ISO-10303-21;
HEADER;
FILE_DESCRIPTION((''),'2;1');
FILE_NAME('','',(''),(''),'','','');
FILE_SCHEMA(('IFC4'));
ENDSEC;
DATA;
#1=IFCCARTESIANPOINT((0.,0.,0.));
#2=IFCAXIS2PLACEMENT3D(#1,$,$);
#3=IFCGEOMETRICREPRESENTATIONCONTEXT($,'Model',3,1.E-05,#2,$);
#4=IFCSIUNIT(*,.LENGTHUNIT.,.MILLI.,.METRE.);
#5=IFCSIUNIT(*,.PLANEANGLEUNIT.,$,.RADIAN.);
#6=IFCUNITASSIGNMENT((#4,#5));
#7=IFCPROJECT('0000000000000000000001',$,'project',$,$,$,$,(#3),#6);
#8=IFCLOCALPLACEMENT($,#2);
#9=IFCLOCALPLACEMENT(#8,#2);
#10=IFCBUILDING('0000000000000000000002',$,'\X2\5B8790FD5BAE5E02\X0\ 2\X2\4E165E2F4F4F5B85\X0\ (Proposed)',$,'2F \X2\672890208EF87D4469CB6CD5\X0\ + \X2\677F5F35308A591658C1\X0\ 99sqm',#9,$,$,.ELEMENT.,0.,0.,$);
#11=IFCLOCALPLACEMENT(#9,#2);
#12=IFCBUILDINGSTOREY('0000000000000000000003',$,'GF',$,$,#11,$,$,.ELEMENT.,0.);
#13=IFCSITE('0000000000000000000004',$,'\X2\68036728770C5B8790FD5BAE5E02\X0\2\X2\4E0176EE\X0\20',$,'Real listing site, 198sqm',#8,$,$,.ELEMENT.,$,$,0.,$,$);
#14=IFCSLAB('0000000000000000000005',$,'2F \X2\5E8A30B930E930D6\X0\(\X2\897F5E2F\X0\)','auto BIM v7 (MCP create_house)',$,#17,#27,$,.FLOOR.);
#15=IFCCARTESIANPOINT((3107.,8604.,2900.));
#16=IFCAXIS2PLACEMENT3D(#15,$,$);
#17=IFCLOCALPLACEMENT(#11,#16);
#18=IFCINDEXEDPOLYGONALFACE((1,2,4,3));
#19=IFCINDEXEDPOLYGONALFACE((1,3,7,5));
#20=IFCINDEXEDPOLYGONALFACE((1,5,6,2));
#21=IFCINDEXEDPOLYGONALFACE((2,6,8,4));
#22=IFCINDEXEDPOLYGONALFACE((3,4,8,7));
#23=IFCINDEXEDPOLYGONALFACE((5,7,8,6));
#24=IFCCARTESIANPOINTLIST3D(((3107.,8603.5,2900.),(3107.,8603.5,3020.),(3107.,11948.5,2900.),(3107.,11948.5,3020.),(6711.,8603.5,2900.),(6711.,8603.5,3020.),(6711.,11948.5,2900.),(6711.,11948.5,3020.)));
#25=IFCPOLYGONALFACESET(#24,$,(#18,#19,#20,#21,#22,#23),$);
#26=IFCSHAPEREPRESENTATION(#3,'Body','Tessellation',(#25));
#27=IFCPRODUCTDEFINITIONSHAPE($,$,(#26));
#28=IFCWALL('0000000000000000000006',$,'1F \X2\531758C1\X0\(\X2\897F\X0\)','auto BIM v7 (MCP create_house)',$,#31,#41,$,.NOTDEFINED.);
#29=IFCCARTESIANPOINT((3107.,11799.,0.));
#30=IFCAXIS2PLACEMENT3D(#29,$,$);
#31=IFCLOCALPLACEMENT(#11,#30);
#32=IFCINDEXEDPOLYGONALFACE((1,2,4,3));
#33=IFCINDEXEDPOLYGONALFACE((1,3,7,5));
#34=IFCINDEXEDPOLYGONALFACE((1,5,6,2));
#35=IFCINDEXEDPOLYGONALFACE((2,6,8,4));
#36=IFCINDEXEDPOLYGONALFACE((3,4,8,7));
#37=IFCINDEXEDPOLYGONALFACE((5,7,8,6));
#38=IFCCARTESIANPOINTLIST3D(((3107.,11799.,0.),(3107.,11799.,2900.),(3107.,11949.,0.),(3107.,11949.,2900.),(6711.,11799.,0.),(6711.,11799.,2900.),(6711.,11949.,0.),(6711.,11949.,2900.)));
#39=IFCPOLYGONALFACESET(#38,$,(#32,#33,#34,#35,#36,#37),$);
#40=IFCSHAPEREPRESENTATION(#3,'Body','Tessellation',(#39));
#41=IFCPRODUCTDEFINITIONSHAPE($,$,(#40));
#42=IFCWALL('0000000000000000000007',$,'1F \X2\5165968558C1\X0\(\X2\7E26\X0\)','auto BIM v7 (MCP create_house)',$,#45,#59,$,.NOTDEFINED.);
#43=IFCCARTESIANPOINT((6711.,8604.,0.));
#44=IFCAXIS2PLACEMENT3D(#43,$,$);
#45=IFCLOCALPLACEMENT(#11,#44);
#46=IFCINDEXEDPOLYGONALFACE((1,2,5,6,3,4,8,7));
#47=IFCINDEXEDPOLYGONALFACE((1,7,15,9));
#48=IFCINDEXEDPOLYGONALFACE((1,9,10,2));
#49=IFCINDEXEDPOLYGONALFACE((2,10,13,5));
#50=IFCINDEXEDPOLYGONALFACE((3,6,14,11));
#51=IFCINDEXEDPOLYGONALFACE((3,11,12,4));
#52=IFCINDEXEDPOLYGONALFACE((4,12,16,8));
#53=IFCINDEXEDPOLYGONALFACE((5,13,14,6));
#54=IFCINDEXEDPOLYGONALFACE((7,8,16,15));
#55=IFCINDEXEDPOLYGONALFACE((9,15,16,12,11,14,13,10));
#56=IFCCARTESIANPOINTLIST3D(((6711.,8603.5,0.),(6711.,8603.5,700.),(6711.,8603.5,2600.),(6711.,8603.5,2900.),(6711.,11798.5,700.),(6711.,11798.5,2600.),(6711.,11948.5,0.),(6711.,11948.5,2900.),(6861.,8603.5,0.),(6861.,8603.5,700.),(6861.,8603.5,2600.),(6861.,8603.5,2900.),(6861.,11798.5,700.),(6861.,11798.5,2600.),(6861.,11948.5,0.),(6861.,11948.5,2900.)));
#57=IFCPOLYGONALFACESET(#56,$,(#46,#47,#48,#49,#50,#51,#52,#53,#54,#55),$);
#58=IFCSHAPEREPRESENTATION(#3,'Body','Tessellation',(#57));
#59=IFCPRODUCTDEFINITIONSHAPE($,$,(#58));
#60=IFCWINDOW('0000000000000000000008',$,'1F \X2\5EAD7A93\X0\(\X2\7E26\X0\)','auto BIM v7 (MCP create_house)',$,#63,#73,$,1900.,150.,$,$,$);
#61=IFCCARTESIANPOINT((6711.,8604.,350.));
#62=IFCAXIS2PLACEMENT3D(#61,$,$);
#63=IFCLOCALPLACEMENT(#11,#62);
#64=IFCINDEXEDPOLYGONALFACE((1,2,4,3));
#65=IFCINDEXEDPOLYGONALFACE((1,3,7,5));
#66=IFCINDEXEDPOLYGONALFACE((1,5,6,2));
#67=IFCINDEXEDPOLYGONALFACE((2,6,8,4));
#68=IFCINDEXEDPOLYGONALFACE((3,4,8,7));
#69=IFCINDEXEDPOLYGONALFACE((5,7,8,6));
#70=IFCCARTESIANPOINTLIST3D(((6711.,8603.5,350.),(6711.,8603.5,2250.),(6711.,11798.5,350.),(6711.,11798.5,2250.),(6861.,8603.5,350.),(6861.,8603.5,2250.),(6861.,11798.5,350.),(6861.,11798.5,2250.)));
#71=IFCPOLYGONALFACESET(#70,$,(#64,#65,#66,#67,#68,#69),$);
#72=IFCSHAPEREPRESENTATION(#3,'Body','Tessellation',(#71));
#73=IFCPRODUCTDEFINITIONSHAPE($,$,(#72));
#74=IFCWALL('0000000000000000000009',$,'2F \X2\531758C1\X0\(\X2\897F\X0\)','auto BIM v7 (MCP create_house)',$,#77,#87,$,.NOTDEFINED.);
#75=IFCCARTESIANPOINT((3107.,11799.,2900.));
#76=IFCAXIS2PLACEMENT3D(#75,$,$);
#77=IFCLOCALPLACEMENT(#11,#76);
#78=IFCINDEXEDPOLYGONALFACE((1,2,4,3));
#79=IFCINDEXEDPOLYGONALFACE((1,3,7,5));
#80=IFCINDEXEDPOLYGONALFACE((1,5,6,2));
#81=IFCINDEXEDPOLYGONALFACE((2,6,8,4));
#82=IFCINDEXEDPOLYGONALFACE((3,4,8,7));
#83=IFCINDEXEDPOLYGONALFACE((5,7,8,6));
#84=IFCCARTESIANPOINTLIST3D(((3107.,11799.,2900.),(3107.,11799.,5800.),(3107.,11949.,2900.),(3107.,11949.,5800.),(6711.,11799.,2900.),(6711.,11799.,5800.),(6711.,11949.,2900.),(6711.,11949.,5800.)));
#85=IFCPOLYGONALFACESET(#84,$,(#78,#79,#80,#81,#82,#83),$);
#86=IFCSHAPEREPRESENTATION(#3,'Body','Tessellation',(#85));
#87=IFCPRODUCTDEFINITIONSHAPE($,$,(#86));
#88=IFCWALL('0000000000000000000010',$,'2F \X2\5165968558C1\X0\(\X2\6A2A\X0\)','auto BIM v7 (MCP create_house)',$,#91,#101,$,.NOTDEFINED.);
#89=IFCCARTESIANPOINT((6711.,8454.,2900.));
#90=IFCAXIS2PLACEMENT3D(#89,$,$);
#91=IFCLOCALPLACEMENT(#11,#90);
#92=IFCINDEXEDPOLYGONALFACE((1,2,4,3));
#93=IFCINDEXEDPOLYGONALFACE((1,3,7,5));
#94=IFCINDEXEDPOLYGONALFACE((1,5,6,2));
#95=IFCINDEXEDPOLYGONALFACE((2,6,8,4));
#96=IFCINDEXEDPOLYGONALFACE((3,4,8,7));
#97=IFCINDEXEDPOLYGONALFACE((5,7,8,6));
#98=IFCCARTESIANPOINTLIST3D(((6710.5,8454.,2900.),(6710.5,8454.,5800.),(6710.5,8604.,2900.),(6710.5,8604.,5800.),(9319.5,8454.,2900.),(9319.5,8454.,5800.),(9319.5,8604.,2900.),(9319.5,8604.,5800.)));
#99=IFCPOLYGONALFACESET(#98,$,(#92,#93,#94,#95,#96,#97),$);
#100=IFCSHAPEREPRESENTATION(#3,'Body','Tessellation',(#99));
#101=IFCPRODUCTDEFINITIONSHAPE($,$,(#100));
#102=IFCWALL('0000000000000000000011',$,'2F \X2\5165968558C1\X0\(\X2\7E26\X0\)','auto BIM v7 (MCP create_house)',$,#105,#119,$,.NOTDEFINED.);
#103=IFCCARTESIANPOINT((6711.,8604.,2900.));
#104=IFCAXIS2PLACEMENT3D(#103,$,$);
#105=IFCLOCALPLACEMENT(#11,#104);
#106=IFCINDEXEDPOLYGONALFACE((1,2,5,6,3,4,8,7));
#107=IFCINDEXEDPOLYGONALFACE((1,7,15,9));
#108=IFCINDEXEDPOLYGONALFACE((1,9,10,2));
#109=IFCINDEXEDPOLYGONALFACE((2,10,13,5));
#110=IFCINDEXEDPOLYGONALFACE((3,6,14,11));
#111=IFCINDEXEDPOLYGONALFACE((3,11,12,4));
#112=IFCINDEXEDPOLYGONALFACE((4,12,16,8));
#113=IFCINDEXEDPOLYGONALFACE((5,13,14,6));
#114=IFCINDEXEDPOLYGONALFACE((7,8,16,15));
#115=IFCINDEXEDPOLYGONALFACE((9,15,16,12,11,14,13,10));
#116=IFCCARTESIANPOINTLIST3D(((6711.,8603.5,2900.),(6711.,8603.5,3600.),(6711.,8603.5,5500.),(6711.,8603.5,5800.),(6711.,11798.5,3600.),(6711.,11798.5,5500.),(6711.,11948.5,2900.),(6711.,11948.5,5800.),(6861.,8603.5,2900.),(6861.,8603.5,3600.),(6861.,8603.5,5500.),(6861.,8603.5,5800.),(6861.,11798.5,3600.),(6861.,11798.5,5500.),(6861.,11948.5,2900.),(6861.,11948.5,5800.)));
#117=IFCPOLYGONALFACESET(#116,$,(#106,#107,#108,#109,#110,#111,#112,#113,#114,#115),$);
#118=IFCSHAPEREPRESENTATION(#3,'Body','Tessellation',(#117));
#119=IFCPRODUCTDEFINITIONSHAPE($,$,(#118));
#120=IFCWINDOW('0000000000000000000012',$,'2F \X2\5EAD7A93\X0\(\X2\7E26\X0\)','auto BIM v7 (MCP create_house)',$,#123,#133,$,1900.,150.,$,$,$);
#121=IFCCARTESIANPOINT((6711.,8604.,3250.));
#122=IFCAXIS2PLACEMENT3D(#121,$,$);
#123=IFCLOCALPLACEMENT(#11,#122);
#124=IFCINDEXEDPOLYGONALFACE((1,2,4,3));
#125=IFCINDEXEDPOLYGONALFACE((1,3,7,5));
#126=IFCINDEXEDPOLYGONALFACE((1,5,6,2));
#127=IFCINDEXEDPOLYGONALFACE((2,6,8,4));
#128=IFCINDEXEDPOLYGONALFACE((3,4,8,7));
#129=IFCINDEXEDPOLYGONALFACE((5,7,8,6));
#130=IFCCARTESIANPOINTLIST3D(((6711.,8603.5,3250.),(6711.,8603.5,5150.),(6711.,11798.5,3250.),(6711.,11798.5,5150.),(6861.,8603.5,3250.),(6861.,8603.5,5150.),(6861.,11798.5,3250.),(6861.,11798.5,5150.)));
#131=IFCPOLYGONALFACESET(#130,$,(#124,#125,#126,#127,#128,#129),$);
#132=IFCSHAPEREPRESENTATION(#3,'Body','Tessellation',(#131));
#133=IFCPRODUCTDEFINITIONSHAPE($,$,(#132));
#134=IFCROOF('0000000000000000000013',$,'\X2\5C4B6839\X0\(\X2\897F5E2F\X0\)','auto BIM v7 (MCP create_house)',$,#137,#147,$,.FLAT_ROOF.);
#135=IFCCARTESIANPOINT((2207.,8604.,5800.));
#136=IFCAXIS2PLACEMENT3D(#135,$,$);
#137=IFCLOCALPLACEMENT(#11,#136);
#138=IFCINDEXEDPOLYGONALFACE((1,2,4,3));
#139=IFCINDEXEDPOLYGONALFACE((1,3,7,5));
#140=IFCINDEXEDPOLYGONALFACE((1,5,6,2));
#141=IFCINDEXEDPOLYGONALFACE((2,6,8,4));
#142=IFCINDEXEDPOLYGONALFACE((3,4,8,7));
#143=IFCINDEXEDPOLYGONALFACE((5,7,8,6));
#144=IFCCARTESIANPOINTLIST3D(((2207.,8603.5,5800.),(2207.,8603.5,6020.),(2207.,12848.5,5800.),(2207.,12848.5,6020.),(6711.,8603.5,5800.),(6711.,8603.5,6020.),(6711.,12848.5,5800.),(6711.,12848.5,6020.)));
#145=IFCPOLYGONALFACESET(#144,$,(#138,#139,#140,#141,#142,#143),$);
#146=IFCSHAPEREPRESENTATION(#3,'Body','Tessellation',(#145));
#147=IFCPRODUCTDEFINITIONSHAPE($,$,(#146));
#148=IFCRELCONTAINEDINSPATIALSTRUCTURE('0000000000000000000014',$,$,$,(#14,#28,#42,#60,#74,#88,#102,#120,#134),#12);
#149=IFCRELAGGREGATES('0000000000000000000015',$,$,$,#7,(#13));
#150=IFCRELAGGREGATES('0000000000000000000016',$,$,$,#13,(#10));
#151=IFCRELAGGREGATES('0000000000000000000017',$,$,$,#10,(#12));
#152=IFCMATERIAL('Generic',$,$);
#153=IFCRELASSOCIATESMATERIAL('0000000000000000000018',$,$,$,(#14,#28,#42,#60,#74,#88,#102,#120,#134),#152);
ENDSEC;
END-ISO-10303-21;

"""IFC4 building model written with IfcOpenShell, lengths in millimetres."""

from ifc_helpers import new_model, si_unit, frame, frame_2d, origin, place, context, project, spatial, rectangle, extrude, material, element, fill, save


model = new_model("IFC4")

# Units and contexts
model_context = context("Model", 3, precision=1e-05, world=origin())
ifc_project = project(units=[si_unit("LENGTHUNIT", "METRE", prefix="MILLI"), si_unit("PLANEANGLEUNIT", "RADIAN")], contexts=[model_context])

# Site, building, storey
site_placement = place(None, origin())
site = spatial("IfcSite", under=ifc_project, at=site_placement, Name="栃木県宇都宮市2丁目20", ObjectType="Real listing site, 198sqm", CompositionType="ELEMENT", RefElevation=0.0)
building_placement = place(site_placement, origin())
building = spatial("IfcBuilding", under=site, at=building_placement, Name="宇都宮市 2世帯住宅 (Proposed)", ObjectType="2F 木造軸組構法 + 板張り外壁 99sqm", CompositionType="ELEMENT", ElevationOfRefHeight=0.0, ElevationOfTerrain=0.0)
storey_placement = place(building_placement, origin())
storey = spatial("IfcBuildingStorey", under=building, at=storey_placement, Name="GF", CompositionType="ELEMENT", Elevation=0.0)

# Slab
ifc_material = material(Name="Generic")
slab_1_placement = place(storey_placement, frame((3107.0, 8604.0, 2900.0)))
element("IfcSlab", 1, at=slab_1_placement, inside=storey, material=ifc_material, Name="2F 床スラブ(西帯)", Description="auto BIM v7 (MCP create_house)", PredefinedType="FLOOR", context=model_context, shape_type="SweptSolid", body=[
    extrude(rectangle(XDim=3604.0, YDim=3345.0, at=frame_2d((1802.0, 1672.0))), frame((3107.0, 8604.0, 2900.0)), (0.0, 0.0, 1.0), 120.0),
])

# Wall
wall_1_placement = place(storey_placement, frame((3107.0, 11799.0, 0.0)))
element("IfcWall", 2, at=wall_1_placement, inside=storey, material=ifc_material, Name="1F 北壁(西)", Description="auto BIM v7 (MCP create_house)", PredefinedType="NOTDEFINED", context=model_context, shape_type="SweptSolid", body=[
    extrude(rectangle(XDim=3604.0, YDim=150.0, at=frame_2d((1802.0, 75.0))), frame((3107.0, 11799.0, 0.0)), (0.0, 0.0, 1.0), 2900.0),
])

# Wall, opening, window
wall_2_placement = place(storey_placement, frame((6711.0, 8604.0, 0.0)))
wall_2 = element("IfcWall", 3, at=wall_2_placement, inside=storey, material=ifc_material, Name="1F 入隅壁(縦)", Description="auto BIM v7 (MCP create_house)", PredefinedType="NOTDEFINED", context=model_context, shape_type="SweptSolid", body=[
    extrude(rectangle(XDim=150.0, YDim=3345.0, at=frame_2d((75.0, 1672.0))), frame((6711.0, 8604.0, 0.0)), (0.0, 0.0, 1.0), 2900.0),
])
opening_1_placement = place(storey_placement, frame((6711.0, 8604.0, 350.0)))
opening_1 = element("IfcOpeningElement", 4, at=opening_1_placement, cuts=wall_2, PredefinedType="NOTDEFINED", context=model_context, shape_type="SweptSolid", body=[
    extrude(rectangle(XDim=150.0, YDim=3195.0, at=frame_2d((75.0, 1597.0))), frame((6711.0, 8604.0, 350.0)), (0.0, 0.0, 1.0), 1900.0),
])
window_1_placement = place(storey_placement, frame((6711.0, 8604.0, 350.0)))
window_1 = element("IfcWindow", 5, at=window_1_placement, inside=storey, material=ifc_material, Name="1F 庭窓(縦)", Description="auto BIM v7 (MCP create_house)", OverallHeight=1900.0, OverallWidth=150.0, context=model_context, shape_type="SweptSolid", body=[
    extrude(rectangle(XDim=150.0, YDim=3195.0, at=frame_2d((75.0, 1597.0))), frame((6711.0, 8604.0, 350.0)), (0.0, 0.0, 1.0), 1900.0),
])
fill(opening_1, window_1)

# Walls
wall_3_placement = place(storey_placement, frame((3107.0, 11799.0, 2900.0)))
element("IfcWall", 6, at=wall_3_placement, inside=storey, material=ifc_material, Name="2F 北壁(西)", Description="auto BIM v7 (MCP create_house)", PredefinedType="NOTDEFINED", context=model_context, shape_type="SweptSolid", body=[
    extrude(rectangle(XDim=3604.0, YDim=150.0, at=frame_2d((1802.0, 75.0))), frame((3107.0, 11799.0, 2900.0)), (0.0, 0.0, 1.0), 2900.0),
])
wall_4_placement = place(storey_placement, frame((6711.0, 8454.0, 2900.0)))
element("IfcWall", 7, at=wall_4_placement, inside=storey, material=ifc_material, Name="2F 入隅壁(横)", Description="auto BIM v7 (MCP create_house)", PredefinedType="NOTDEFINED", context=model_context, shape_type="SweptSolid", body=[
    extrude(rectangle(XDim=2609.0, YDim=150.0, at=frame_2d((1304.0, 75.0))), frame((6711.0, 8454.0, 2900.0)), (0.0, 0.0, 1.0), 2900.0),
])

# Wall, opening, window
wall_5_placement = place(storey_placement, frame((6711.0, 8604.0, 2900.0)))
wall_5 = element("IfcWall", 8, at=wall_5_placement, inside=storey, material=ifc_material, Name="2F 入隅壁(縦)", Description="auto BIM v7 (MCP create_house)", PredefinedType="NOTDEFINED", context=model_context, shape_type="SweptSolid", body=[
    extrude(rectangle(XDim=150.0, YDim=3345.0, at=frame_2d((75.0, 1672.0))), frame((6711.0, 8604.0, 2900.0)), (0.0, 0.0, 1.0), 2900.0),
])
opening_2_placement = place(storey_placement, frame((6711.0, 8604.0, 3250.0)))
opening_2 = element("IfcOpeningElement", 9, at=opening_2_placement, cuts=wall_5, PredefinedType="NOTDEFINED", context=model_context, shape_type="SweptSolid", body=[
    extrude(rectangle(XDim=150.0, YDim=3195.0, at=frame_2d((75.0, 1597.0))), frame((6711.0, 8604.0, 3250.0)), (0.0, 0.0, 1.0), 1900.0),
])
window_2_placement = place(storey_placement, frame((6711.0, 8604.0, 3250.0)))
window_2 = element("IfcWindow", 10, at=window_2_placement, inside=storey, material=ifc_material, Name="2F 庭窓(縦)", Description="auto BIM v7 (MCP create_house)", OverallHeight=1900.0, OverallWidth=150.0, context=model_context, shape_type="SweptSolid", body=[
    extrude(rectangle(XDim=150.0, YDim=3195.0, at=frame_2d((75.0, 1597.0))), frame((6711.0, 8604.0, 3250.0)), (0.0, 0.0, 1.0), 1900.0),
])
fill(opening_2, window_2)

# Roof
for number, where, name in (
    (11, (2207.0, 8604.0, 5800.0), "屋根(西帯)"),
):
    element("IfcRoof", number, at=place(storey_placement, frame(where)), inside=storey, material=ifc_material, Name=name, Description="auto BIM v7 (MCP create_house)", PredefinedType="FLAT_ROOF", context=model_context, shape_type="SweptSolid", body=[
        extrude(rectangle(XDim=4504.0, YDim=4245.0, at=frame_2d((2252.0, 2122.0))), frame((2207.0, 8604.0, 5800.0)), (0.0, 0.0, 1.0), 220.0),
    ])

save(model, "model.ifc")
